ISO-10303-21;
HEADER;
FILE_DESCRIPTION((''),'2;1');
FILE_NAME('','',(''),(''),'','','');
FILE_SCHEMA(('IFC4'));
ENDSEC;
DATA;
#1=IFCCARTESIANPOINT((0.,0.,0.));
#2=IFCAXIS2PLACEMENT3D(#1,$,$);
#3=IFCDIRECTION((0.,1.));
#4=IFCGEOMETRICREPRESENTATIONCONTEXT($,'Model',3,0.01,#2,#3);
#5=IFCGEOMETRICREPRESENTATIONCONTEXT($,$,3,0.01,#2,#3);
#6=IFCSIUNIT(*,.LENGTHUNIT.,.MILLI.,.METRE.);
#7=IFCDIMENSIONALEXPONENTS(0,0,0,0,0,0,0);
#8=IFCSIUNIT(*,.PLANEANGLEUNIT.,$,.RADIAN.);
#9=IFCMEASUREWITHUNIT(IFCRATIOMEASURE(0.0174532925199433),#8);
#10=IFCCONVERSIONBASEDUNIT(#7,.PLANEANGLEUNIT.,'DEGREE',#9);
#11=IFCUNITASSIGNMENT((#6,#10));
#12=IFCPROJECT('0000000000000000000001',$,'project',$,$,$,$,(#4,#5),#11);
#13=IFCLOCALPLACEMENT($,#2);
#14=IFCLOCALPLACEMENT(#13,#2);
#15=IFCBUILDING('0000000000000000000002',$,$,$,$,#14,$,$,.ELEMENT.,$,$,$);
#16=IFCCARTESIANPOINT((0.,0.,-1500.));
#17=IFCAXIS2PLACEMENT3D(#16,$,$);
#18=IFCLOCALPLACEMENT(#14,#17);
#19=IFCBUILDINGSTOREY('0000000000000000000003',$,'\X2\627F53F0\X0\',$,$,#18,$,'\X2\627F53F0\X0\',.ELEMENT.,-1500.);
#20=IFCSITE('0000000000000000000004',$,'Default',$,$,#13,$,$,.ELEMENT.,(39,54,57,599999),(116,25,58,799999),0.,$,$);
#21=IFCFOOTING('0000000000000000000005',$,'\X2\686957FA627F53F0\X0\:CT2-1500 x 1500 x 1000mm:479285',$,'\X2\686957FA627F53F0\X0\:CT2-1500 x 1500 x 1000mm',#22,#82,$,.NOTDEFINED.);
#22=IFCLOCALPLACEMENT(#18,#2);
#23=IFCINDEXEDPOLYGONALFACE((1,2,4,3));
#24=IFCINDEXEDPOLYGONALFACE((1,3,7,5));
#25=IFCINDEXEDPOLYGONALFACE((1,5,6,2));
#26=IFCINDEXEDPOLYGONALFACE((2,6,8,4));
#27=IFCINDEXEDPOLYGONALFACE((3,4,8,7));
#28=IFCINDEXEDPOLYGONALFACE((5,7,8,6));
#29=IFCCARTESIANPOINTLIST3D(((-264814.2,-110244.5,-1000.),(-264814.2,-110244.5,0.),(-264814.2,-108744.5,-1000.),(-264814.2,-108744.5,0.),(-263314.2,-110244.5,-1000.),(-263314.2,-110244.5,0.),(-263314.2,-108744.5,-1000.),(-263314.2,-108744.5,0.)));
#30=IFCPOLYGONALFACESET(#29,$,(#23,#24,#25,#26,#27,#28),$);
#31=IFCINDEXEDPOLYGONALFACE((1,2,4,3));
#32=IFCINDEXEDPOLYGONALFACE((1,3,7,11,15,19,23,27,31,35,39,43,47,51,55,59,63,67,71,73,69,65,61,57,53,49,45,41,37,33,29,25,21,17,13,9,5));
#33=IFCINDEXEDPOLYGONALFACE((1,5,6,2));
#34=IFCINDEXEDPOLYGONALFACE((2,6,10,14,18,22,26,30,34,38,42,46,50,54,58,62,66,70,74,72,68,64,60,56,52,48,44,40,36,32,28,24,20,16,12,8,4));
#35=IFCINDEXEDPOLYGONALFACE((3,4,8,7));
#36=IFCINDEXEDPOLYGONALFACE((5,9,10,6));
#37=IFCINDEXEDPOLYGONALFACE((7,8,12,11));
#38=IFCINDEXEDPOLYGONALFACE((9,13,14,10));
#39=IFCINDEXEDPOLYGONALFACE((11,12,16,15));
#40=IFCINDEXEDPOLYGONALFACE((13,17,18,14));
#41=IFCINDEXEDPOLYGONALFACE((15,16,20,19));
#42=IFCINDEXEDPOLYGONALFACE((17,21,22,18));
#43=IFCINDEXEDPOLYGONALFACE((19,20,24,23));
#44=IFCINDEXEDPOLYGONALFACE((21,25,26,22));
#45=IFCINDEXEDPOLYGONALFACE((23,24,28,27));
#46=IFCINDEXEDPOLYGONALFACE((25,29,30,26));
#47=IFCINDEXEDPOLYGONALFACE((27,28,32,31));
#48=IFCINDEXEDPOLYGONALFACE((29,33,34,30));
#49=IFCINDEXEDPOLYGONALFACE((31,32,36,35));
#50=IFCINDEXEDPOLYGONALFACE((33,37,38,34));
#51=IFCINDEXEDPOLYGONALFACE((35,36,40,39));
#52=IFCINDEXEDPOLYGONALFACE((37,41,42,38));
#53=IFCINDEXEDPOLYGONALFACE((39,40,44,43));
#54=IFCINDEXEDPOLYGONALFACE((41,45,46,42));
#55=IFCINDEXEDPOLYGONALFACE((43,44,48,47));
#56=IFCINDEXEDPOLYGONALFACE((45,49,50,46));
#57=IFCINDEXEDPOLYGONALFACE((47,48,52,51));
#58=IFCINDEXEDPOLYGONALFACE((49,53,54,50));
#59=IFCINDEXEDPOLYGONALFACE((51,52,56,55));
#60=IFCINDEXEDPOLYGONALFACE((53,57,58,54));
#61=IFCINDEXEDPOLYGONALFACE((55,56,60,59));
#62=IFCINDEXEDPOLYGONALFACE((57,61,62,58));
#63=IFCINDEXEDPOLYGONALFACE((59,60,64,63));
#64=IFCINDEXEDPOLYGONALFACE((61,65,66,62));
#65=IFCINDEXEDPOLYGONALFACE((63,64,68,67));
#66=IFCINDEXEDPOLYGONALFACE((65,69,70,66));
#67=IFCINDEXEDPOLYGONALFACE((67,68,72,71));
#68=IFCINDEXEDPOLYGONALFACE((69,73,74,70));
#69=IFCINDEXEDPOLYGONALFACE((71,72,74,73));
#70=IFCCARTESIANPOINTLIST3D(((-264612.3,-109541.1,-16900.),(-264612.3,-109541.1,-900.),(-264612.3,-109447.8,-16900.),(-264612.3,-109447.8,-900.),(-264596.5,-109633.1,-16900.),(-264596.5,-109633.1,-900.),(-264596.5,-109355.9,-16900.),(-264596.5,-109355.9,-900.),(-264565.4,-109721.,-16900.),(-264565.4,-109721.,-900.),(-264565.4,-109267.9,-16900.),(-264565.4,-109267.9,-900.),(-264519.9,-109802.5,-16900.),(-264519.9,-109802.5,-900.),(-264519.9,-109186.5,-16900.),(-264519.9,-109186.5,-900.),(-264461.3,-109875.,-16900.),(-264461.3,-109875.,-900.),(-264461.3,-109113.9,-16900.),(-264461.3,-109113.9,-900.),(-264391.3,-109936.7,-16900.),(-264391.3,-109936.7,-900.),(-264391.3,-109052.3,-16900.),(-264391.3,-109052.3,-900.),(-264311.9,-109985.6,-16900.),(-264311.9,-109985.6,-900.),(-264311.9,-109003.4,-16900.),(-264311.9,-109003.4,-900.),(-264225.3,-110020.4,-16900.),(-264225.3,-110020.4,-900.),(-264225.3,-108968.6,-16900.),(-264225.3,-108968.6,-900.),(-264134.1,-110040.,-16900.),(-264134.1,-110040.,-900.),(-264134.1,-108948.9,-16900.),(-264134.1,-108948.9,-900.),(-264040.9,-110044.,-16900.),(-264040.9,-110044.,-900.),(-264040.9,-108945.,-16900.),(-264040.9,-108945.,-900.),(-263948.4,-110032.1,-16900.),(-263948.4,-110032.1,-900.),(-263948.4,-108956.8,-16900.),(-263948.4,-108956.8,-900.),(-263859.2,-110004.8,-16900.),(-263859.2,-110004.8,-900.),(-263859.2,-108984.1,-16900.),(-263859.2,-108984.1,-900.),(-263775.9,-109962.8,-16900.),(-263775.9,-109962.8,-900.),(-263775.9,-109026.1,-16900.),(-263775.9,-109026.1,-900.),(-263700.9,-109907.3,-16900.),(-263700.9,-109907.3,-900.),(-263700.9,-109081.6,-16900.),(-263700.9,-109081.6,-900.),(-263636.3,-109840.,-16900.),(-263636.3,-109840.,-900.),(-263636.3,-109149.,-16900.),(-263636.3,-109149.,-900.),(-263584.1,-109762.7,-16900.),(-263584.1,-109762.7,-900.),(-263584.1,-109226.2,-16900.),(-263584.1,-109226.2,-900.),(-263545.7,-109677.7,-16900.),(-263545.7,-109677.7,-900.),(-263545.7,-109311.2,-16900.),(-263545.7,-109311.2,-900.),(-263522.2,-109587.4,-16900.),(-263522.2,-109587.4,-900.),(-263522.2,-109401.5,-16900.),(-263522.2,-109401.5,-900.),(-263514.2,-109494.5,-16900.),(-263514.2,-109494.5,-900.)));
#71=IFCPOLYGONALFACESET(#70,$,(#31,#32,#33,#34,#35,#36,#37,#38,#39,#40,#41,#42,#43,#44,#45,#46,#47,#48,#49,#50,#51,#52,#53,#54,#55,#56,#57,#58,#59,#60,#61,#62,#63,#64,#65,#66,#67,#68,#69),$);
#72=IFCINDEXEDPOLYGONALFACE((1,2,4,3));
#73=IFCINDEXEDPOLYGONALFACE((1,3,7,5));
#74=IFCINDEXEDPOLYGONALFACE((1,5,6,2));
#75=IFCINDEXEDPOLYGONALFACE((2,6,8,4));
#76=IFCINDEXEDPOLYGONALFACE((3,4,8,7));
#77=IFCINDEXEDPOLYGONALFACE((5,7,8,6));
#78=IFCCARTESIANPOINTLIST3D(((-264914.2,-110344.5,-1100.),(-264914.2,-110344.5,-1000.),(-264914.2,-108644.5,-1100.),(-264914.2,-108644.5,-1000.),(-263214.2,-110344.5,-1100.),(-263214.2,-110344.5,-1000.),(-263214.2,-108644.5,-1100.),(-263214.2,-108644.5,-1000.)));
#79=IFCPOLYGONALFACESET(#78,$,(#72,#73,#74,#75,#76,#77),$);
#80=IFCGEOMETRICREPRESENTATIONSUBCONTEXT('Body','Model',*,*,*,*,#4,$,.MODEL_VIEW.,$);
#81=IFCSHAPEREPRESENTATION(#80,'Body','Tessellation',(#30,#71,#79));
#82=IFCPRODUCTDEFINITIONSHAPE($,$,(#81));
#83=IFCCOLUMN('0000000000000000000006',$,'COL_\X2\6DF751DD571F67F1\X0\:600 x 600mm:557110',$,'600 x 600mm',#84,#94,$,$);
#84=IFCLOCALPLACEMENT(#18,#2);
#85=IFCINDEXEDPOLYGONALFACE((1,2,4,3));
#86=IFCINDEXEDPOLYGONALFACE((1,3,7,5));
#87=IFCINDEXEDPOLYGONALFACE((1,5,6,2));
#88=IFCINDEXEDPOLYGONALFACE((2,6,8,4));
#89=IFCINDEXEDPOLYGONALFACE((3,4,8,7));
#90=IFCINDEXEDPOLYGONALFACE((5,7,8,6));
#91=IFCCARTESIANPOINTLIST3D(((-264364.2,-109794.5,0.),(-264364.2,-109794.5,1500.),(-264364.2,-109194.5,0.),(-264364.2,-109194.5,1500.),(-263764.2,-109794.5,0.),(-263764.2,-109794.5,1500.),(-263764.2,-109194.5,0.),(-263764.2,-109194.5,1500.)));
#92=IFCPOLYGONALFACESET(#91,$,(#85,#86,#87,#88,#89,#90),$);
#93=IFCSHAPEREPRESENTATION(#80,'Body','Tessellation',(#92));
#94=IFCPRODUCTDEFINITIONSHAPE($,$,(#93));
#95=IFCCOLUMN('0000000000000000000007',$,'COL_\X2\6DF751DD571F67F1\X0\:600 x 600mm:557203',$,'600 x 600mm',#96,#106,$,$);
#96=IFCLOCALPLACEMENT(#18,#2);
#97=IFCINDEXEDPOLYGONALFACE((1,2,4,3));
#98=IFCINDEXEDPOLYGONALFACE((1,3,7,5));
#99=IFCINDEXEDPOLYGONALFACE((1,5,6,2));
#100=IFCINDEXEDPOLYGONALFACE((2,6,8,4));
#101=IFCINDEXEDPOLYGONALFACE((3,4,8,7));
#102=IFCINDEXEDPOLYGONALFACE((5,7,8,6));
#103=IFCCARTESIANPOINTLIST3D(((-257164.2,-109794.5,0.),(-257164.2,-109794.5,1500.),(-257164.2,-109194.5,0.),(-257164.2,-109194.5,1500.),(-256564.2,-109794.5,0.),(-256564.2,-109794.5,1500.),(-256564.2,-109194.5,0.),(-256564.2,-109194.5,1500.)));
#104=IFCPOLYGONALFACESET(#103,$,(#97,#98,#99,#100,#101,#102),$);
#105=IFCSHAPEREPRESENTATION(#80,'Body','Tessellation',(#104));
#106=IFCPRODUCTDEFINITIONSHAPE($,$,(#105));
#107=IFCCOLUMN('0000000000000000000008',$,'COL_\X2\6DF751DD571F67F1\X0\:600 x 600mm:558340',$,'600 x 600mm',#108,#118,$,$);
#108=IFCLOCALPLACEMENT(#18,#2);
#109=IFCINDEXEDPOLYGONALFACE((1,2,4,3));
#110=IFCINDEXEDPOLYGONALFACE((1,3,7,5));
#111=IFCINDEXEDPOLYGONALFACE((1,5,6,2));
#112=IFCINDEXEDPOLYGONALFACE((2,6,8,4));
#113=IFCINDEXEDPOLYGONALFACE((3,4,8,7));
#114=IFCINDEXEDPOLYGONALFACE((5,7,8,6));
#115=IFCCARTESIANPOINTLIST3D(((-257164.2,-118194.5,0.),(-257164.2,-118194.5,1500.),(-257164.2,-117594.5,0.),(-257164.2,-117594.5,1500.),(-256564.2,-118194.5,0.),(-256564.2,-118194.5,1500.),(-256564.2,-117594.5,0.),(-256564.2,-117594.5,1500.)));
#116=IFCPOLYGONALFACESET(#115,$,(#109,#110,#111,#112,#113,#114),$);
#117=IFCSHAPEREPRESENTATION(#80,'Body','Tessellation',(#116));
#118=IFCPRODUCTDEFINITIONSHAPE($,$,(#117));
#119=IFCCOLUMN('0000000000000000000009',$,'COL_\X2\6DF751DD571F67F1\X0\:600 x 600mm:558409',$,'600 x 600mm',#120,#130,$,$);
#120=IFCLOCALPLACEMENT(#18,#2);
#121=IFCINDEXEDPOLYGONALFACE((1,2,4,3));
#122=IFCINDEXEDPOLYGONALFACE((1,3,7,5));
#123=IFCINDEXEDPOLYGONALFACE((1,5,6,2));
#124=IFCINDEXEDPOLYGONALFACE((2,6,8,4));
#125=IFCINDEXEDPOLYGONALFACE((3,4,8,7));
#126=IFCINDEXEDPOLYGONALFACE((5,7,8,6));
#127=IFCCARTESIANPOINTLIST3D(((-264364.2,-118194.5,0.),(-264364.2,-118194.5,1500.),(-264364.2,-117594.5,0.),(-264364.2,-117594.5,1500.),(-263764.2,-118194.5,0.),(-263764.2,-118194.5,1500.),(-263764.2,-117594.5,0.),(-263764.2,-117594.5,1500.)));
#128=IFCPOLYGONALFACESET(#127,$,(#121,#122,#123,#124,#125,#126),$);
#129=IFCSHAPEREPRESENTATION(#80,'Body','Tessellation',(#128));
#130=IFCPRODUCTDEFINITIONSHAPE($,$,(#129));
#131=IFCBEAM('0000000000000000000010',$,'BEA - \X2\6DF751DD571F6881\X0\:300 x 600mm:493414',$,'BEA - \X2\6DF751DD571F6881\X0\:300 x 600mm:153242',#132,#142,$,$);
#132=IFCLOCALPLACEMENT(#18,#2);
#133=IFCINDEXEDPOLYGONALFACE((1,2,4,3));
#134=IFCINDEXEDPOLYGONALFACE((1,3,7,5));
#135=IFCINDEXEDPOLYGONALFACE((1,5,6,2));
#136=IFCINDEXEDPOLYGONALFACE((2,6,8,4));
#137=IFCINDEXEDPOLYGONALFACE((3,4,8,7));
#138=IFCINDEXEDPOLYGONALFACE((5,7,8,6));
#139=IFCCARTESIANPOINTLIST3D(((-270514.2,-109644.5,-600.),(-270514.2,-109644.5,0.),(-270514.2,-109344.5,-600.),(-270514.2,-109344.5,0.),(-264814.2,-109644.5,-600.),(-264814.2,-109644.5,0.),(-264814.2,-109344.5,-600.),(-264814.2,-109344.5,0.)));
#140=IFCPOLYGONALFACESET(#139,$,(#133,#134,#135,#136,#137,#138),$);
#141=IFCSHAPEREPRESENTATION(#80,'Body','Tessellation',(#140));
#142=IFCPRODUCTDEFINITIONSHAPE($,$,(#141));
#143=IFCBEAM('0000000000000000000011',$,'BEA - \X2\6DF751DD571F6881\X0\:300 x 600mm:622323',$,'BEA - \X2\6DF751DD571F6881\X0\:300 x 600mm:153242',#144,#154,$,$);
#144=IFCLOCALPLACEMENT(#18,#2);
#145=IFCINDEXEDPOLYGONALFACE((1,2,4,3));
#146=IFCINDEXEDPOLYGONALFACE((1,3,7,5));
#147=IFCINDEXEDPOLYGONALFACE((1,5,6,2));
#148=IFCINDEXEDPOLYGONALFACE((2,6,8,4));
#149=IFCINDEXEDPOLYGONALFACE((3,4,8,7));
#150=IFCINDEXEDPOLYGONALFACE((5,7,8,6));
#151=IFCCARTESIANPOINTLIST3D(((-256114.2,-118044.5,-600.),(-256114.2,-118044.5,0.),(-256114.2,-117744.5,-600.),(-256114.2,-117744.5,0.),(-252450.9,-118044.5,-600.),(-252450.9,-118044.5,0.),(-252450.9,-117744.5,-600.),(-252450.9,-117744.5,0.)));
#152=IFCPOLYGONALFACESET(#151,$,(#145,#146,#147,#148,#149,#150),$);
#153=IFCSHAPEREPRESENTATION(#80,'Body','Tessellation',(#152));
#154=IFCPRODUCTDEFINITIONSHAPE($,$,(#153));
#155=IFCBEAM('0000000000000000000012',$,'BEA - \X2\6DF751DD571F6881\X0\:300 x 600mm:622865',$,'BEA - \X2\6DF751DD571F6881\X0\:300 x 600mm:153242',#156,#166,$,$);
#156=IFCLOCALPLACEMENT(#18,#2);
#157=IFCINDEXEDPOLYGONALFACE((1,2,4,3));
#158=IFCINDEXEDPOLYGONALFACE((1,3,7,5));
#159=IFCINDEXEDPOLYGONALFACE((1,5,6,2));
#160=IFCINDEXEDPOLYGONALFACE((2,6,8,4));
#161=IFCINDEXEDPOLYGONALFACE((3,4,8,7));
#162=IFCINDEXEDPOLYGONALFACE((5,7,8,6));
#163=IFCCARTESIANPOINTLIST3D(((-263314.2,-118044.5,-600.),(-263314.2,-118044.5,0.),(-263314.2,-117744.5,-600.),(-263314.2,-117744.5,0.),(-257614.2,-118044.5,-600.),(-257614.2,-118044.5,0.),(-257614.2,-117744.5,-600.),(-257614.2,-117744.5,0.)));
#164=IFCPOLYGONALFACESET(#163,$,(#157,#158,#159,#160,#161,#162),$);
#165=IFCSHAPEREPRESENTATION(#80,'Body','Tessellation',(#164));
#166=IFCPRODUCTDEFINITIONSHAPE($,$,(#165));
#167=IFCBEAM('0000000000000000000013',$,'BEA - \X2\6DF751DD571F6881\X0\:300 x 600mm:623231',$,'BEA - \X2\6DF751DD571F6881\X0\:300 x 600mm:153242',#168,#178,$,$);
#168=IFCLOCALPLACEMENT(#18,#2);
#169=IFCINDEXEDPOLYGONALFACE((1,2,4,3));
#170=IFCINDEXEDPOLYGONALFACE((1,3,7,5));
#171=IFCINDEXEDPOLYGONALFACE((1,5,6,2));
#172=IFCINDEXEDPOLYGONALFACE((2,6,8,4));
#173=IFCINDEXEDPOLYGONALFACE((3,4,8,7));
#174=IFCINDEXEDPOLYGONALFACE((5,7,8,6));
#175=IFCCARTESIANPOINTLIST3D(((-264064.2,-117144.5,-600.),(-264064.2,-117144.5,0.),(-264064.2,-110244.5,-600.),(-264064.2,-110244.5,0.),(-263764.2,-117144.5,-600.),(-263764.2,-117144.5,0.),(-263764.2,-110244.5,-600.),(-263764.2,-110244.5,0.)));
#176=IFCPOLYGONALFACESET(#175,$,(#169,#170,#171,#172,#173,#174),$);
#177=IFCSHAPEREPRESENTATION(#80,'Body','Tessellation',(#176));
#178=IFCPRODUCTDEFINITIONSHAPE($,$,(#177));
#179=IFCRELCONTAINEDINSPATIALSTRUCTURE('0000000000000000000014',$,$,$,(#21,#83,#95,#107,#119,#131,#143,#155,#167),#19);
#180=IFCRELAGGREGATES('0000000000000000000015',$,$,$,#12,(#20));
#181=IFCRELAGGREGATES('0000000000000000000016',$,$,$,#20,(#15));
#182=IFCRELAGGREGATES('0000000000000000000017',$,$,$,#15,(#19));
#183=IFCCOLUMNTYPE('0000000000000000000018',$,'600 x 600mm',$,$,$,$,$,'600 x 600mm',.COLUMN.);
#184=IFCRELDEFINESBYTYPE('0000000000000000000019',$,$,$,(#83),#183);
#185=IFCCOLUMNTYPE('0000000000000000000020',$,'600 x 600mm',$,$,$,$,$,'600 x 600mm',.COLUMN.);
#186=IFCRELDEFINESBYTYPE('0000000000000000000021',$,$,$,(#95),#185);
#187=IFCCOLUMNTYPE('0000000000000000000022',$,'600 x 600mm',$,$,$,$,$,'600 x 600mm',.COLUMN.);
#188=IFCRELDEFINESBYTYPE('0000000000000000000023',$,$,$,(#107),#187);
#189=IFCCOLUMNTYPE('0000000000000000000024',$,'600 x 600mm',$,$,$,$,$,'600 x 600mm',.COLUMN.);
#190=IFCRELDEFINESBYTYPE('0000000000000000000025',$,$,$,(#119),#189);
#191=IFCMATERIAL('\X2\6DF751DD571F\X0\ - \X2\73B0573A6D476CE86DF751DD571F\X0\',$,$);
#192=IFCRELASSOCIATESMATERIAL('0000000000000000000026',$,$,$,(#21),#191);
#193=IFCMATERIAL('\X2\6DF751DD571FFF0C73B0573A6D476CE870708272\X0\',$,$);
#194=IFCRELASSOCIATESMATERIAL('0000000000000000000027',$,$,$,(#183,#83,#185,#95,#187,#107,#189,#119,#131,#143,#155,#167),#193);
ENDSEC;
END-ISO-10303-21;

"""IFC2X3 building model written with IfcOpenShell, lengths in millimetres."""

from ifc_helpers import new_model, entity, si_unit, converted_unit, direction, frame, frame_2d, origin, origin_2d_with_axis, place, context, subcontext, project, spatial, rectangle, circle, extrude, source, transform, mapped, material, type_object, type_shapes, element, save


model = new_model("IFC2X3")

# Units and contexts
model_context = context("Model", 3, precision=0.01, world=origin(), true_north=direction((0.0, 1.0)))
context_of_model = context(None, 3, precision=0.01, world=origin(), true_north=direction((0.0, 1.0)))
body_context = subcontext(model_context, "Body", "Model", "MODEL_VIEW")
ifc_project = project(units=[si_unit("LENGTHUNIT", "METRE", prefix="MILLI"), converted_unit("PLANEANGLEUNIT", "DEGREE", entity("IfcRatioMeasure", 0.0174532925199433), si_unit("PLANEANGLEUNIT", "RADIAN"), dimensions=[0, 0, 0, 0, 0, 0, 0])], contexts=[model_context, context_of_model])

# Site, building, storey
site_placement = place(None, origin())
site = spatial("IfcSite", under=ifc_project, at=site_placement, Name="Default", CompositionType="ELEMENT", RefLatitude=(39, 54, 57, 599999), RefLongitude=(116, 25, 58, 799999), RefElevation=0.0)
building_placement = place(site_placement, origin())
building = spatial("IfcBuilding", under=site, at=building_placement, CompositionType="ELEMENT")
storey_placement = place(building_placement, frame((0.0, 0.0, -1500.0)))
storey = spatial("IfcBuildingStorey", under=building, at=storey_placement, Name="承台", LongName="承台", CompositionType="ELEMENT", Elevation=-1500.0)

# Footing
ifc_material_1 = material(Name="混凝土 - 现场浇注混凝土")
for number, where, name in (
    (1, (-264914.2, -110344.5, -16900.0), "桩基承台:CT2-1500 x 1500 x 1000mm:479285"),
):
    element("IfcFooting", number, at=place(storey_placement, frame(where)), inside=storey, material=ifc_material_1, Name=name, ObjectType="桩基承台:CT2-1500 x 1500 x 1000mm", PredefinedType="NOTDEFINED", context=body_context, shape_type="SweptSolid", body=[
        extrude(rectangle(XDim=1500.0, YDim=1500.0, at=origin_2d_with_axis()), frame((850.0, 850.0, 15900.0), z_axis=(0.0, 0.0, 1.0), x_axis=(-1.0, 0.0, 0.0)), (0.0, 0.0, 1.0), 1000.0),
        extrude(circle(Radius=550.0, at=origin_2d_with_axis()), frame((850.0, 850.0, 0.0)), (0.0, 0.0, 1.0), 16000.0),
        extrude(rectangle(XDim=1700.0, YDim=1700.0, at=frame_2d((0.0, 0.0), x_axis=(1.0, 0.0))), frame((850.0, 850.0, 15800.0), z_axis=(0.0, 0.0, 1.0), x_axis=(0.0, 1.0, 0.0)), (0.0, 0.0, 1.0), 100.0),
    ])

# Columns
ifc_material_2 = material(Name="混凝土，现场浇注灰色")
column_type_1 = type_object("IfcColumnType", Name="600 x 600mm", ElementType="600 x 600mm", PredefinedType="COLUMN", material=ifc_material_2)
shared_shape_1 = source(origin(), body_context, "Body", "SweptSolid", [
    extrude(rectangle(XDim=600.0, YDim=600.0, at=origin_2d_with_axis()), frame((300.0, 300.0, 0.0), z_axis=(0.0, 0.0, 1.0), x_axis=(-1.0, 0.0, 0.0)), (0.0, 0.0, 1.0), 1500.0),
])
type_shapes(column_type_1, [shared_shape_1])
column_1_placement = place(storey_placement, frame((-264364.2, -109794.5, 0.0)))
element("IfcColumn", 2, at=column_1_placement, inside=storey, type_object=column_type_1, material=ifc_material_2, Name="COL_混凝土柱:600 x 600mm:557110", ObjectType="600 x 600mm", context=body_context, shape_type="MappedRepresentation", body=[
    mapped(shared_shape_1, transform((0.0, 0.0, 0.0), scale=1.0)),
])
column_type_2 = type_object("IfcColumnType", Name="600 x 600mm", ElementType="600 x 600mm", PredefinedType="COLUMN", material=ifc_material_2)
shared_shape_2 = source(origin(), body_context, "Body", "SweptSolid", [
    extrude(rectangle(XDim=600.0, YDim=600.0, at=origin_2d_with_axis()), frame((300.0, 300.0, 0.0), z_axis=(0.0, 0.0, 1.0), x_axis=(-1.0, 0.0, 0.0)), (0.0, 0.0, 1.0), 1500.0),
])
type_shapes(column_type_2, [shared_shape_2])
column_2_placement = place(storey_placement, frame((-257164.2, -109794.5, 0.0)))
element("IfcColumn", 3, at=column_2_placement, inside=storey, type_object=column_type_2, material=ifc_material_2, Name="COL_混凝土柱:600 x 600mm:557203", ObjectType="600 x 600mm", context=body_context, shape_type="MappedRepresentation", body=[
    mapped(shared_shape_2, transform((0.0, 0.0, 0.0), scale=1.0)),
])
column_type_3 = type_object("IfcColumnType", Name="600 x 600mm", ElementType="600 x 600mm", PredefinedType="COLUMN", material=ifc_material_2)
shared_shape_3 = source(origin(), body_context, "Body", "SweptSolid", [
    extrude(rectangle(XDim=600.0, YDim=600.0, at=origin_2d_with_axis()), frame((300.0, 300.0, 0.0), z_axis=(0.0, 0.0, 1.0), x_axis=(-1.0, 0.0, 0.0)), (0.0, 0.0, 1.0), 1500.0),
])
type_shapes(column_type_3, [shared_shape_3])
column_3_placement = place(storey_placement, frame((-257164.2, -118194.5, 0.0)))
element("IfcColumn", 4, at=column_3_placement, inside=storey, type_object=column_type_3, material=ifc_material_2, Name="COL_混凝土柱:600 x 600mm:558340", ObjectType="600 x 600mm", context=body_context, shape_type="MappedRepresentation", body=[
    mapped(shared_shape_3, transform((0.0, 0.0, 0.0), scale=1.0)),
])
column_type_4 = type_object("IfcColumnType", Name="600 x 600mm", ElementType="600 x 600mm", PredefinedType="COLUMN", material=ifc_material_2)
shared_shape_4 = source(origin(), body_context, "Body", "SweptSolid", [
    extrude(rectangle(XDim=600.0, YDim=600.0, at=origin_2d_with_axis()), frame((300.0, 300.0, 0.0), z_axis=(0.0, 0.0, 1.0), x_axis=(-1.0, 0.0, 0.0)), (0.0, 0.0, 1.0), 1500.0),
])
type_shapes(column_type_4, [shared_shape_4])
column_4_placement = place(storey_placement, frame((-264364.2, -118194.5, 0.0)))
element("IfcColumn", 5, at=column_4_placement, inside=storey, type_object=column_type_4, material=ifc_material_2, Name="COL_混凝土柱:600 x 600mm:558409", ObjectType="600 x 600mm", context=body_context, shape_type="MappedRepresentation", body=[
    mapped(shared_shape_4, transform((0.0, 0.0, 0.0), scale=1.0)),
])

# Beams
beam_1_placement = place(storey_placement, frame((-264814.2, -109494.5, 0.0), z_axis=(0.0, 0.0, 1.0), x_axis=(-1.0, 0.0, 0.0)))
element("IfcBeam", 6, at=beam_1_placement, inside=storey, material=ifc_material_2, Name="BEA - 混凝土梁:300 x 600mm:493414", ObjectType="BEA - 混凝土梁:300 x 600mm:153242", context=body_context, shape_type="SweptSolid", body=[
    extrude(rectangle(XDim=600.0, YDim=300.0, at=frame_2d((0.0, 0.0), x_axis=(1.0, 0.0))), frame((0.0, 0.0, -300.0), z_axis=(1.0, 0.0, 0.0), x_axis=(0.0, 0.0, -1.0)), (0.0, 0.0, 1.0), 5700.0),
])
beam_2_placement = place(storey_placement, frame((-252450.9, -117894.5, 0.0), z_axis=(0.0, 0.0, 1.0), x_axis=(-1.0, 0.0, 0.0)))
element("IfcBeam", 7, at=beam_2_placement, inside=storey, material=ifc_material_2, Name="BEA - 混凝土梁:300 x 600mm:622323", ObjectType="BEA - 混凝土梁:300 x 600mm:153242", context=body_context, shape_type="SweptSolid", body=[
    extrude(rectangle(XDim=600.0, YDim=300.0, at=frame_2d((0.0, 0.0), x_axis=(1.0, 0.0))), frame((0.0, 0.0, -300.0), z_axis=(1.0, 0.0, 0.0), x_axis=(0.0, 0.0, -1.0)), (0.0, 0.0, 1.0), 3663.3),
])
beam_3_placement = place(storey_placement, frame((-257614.2, -117894.5, 0.0), z_axis=(0.0, 0.0, 1.0), x_axis=(-1.0, 0.0, 0.0)))
element("IfcBeam", 8, at=beam_3_placement, inside=storey, material=ifc_material_2, Name="BEA - 混凝土梁:300 x 600mm:622865", ObjectType="BEA - 混凝土梁:300 x 600mm:153242", context=body_context, shape_type="SweptSolid", body=[
    extrude(rectangle(XDim=600.0, YDim=300.0, at=frame_2d((0.0, 0.0), x_axis=(1.0, 0.0))), frame((0.0, 0.0, -300.0), z_axis=(1.0, 0.0, 0.0), x_axis=(0.0, 0.0, -1.0)), (0.0, 0.0, 1.0), 5700.0),
])
beam_4_placement = place(storey_placement, frame((-263914.2, -117144.5, 0.0), z_axis=(0.0, 0.0, 1.0), x_axis=(0.0, 1.0, 0.0)))
element("IfcBeam", 9, at=beam_4_placement, inside=storey, material=ifc_material_2, Name="BEA - 混凝土梁:300 x 600mm:623231", ObjectType="BEA - 混凝土梁:300 x 600mm:153242", context=body_context, shape_type="SweptSolid", body=[
    extrude(rectangle(XDim=600.0, YDim=300.0, at=origin_2d_with_axis()), frame((0.0, 0.0, -300.0), z_axis=(1.0, 0.0, 0.0), x_axis=(0.0, 0.0, -1.0)), (0.0, 0.0, 1.0), 6900.0),
])

save(model, "model.ifc")
